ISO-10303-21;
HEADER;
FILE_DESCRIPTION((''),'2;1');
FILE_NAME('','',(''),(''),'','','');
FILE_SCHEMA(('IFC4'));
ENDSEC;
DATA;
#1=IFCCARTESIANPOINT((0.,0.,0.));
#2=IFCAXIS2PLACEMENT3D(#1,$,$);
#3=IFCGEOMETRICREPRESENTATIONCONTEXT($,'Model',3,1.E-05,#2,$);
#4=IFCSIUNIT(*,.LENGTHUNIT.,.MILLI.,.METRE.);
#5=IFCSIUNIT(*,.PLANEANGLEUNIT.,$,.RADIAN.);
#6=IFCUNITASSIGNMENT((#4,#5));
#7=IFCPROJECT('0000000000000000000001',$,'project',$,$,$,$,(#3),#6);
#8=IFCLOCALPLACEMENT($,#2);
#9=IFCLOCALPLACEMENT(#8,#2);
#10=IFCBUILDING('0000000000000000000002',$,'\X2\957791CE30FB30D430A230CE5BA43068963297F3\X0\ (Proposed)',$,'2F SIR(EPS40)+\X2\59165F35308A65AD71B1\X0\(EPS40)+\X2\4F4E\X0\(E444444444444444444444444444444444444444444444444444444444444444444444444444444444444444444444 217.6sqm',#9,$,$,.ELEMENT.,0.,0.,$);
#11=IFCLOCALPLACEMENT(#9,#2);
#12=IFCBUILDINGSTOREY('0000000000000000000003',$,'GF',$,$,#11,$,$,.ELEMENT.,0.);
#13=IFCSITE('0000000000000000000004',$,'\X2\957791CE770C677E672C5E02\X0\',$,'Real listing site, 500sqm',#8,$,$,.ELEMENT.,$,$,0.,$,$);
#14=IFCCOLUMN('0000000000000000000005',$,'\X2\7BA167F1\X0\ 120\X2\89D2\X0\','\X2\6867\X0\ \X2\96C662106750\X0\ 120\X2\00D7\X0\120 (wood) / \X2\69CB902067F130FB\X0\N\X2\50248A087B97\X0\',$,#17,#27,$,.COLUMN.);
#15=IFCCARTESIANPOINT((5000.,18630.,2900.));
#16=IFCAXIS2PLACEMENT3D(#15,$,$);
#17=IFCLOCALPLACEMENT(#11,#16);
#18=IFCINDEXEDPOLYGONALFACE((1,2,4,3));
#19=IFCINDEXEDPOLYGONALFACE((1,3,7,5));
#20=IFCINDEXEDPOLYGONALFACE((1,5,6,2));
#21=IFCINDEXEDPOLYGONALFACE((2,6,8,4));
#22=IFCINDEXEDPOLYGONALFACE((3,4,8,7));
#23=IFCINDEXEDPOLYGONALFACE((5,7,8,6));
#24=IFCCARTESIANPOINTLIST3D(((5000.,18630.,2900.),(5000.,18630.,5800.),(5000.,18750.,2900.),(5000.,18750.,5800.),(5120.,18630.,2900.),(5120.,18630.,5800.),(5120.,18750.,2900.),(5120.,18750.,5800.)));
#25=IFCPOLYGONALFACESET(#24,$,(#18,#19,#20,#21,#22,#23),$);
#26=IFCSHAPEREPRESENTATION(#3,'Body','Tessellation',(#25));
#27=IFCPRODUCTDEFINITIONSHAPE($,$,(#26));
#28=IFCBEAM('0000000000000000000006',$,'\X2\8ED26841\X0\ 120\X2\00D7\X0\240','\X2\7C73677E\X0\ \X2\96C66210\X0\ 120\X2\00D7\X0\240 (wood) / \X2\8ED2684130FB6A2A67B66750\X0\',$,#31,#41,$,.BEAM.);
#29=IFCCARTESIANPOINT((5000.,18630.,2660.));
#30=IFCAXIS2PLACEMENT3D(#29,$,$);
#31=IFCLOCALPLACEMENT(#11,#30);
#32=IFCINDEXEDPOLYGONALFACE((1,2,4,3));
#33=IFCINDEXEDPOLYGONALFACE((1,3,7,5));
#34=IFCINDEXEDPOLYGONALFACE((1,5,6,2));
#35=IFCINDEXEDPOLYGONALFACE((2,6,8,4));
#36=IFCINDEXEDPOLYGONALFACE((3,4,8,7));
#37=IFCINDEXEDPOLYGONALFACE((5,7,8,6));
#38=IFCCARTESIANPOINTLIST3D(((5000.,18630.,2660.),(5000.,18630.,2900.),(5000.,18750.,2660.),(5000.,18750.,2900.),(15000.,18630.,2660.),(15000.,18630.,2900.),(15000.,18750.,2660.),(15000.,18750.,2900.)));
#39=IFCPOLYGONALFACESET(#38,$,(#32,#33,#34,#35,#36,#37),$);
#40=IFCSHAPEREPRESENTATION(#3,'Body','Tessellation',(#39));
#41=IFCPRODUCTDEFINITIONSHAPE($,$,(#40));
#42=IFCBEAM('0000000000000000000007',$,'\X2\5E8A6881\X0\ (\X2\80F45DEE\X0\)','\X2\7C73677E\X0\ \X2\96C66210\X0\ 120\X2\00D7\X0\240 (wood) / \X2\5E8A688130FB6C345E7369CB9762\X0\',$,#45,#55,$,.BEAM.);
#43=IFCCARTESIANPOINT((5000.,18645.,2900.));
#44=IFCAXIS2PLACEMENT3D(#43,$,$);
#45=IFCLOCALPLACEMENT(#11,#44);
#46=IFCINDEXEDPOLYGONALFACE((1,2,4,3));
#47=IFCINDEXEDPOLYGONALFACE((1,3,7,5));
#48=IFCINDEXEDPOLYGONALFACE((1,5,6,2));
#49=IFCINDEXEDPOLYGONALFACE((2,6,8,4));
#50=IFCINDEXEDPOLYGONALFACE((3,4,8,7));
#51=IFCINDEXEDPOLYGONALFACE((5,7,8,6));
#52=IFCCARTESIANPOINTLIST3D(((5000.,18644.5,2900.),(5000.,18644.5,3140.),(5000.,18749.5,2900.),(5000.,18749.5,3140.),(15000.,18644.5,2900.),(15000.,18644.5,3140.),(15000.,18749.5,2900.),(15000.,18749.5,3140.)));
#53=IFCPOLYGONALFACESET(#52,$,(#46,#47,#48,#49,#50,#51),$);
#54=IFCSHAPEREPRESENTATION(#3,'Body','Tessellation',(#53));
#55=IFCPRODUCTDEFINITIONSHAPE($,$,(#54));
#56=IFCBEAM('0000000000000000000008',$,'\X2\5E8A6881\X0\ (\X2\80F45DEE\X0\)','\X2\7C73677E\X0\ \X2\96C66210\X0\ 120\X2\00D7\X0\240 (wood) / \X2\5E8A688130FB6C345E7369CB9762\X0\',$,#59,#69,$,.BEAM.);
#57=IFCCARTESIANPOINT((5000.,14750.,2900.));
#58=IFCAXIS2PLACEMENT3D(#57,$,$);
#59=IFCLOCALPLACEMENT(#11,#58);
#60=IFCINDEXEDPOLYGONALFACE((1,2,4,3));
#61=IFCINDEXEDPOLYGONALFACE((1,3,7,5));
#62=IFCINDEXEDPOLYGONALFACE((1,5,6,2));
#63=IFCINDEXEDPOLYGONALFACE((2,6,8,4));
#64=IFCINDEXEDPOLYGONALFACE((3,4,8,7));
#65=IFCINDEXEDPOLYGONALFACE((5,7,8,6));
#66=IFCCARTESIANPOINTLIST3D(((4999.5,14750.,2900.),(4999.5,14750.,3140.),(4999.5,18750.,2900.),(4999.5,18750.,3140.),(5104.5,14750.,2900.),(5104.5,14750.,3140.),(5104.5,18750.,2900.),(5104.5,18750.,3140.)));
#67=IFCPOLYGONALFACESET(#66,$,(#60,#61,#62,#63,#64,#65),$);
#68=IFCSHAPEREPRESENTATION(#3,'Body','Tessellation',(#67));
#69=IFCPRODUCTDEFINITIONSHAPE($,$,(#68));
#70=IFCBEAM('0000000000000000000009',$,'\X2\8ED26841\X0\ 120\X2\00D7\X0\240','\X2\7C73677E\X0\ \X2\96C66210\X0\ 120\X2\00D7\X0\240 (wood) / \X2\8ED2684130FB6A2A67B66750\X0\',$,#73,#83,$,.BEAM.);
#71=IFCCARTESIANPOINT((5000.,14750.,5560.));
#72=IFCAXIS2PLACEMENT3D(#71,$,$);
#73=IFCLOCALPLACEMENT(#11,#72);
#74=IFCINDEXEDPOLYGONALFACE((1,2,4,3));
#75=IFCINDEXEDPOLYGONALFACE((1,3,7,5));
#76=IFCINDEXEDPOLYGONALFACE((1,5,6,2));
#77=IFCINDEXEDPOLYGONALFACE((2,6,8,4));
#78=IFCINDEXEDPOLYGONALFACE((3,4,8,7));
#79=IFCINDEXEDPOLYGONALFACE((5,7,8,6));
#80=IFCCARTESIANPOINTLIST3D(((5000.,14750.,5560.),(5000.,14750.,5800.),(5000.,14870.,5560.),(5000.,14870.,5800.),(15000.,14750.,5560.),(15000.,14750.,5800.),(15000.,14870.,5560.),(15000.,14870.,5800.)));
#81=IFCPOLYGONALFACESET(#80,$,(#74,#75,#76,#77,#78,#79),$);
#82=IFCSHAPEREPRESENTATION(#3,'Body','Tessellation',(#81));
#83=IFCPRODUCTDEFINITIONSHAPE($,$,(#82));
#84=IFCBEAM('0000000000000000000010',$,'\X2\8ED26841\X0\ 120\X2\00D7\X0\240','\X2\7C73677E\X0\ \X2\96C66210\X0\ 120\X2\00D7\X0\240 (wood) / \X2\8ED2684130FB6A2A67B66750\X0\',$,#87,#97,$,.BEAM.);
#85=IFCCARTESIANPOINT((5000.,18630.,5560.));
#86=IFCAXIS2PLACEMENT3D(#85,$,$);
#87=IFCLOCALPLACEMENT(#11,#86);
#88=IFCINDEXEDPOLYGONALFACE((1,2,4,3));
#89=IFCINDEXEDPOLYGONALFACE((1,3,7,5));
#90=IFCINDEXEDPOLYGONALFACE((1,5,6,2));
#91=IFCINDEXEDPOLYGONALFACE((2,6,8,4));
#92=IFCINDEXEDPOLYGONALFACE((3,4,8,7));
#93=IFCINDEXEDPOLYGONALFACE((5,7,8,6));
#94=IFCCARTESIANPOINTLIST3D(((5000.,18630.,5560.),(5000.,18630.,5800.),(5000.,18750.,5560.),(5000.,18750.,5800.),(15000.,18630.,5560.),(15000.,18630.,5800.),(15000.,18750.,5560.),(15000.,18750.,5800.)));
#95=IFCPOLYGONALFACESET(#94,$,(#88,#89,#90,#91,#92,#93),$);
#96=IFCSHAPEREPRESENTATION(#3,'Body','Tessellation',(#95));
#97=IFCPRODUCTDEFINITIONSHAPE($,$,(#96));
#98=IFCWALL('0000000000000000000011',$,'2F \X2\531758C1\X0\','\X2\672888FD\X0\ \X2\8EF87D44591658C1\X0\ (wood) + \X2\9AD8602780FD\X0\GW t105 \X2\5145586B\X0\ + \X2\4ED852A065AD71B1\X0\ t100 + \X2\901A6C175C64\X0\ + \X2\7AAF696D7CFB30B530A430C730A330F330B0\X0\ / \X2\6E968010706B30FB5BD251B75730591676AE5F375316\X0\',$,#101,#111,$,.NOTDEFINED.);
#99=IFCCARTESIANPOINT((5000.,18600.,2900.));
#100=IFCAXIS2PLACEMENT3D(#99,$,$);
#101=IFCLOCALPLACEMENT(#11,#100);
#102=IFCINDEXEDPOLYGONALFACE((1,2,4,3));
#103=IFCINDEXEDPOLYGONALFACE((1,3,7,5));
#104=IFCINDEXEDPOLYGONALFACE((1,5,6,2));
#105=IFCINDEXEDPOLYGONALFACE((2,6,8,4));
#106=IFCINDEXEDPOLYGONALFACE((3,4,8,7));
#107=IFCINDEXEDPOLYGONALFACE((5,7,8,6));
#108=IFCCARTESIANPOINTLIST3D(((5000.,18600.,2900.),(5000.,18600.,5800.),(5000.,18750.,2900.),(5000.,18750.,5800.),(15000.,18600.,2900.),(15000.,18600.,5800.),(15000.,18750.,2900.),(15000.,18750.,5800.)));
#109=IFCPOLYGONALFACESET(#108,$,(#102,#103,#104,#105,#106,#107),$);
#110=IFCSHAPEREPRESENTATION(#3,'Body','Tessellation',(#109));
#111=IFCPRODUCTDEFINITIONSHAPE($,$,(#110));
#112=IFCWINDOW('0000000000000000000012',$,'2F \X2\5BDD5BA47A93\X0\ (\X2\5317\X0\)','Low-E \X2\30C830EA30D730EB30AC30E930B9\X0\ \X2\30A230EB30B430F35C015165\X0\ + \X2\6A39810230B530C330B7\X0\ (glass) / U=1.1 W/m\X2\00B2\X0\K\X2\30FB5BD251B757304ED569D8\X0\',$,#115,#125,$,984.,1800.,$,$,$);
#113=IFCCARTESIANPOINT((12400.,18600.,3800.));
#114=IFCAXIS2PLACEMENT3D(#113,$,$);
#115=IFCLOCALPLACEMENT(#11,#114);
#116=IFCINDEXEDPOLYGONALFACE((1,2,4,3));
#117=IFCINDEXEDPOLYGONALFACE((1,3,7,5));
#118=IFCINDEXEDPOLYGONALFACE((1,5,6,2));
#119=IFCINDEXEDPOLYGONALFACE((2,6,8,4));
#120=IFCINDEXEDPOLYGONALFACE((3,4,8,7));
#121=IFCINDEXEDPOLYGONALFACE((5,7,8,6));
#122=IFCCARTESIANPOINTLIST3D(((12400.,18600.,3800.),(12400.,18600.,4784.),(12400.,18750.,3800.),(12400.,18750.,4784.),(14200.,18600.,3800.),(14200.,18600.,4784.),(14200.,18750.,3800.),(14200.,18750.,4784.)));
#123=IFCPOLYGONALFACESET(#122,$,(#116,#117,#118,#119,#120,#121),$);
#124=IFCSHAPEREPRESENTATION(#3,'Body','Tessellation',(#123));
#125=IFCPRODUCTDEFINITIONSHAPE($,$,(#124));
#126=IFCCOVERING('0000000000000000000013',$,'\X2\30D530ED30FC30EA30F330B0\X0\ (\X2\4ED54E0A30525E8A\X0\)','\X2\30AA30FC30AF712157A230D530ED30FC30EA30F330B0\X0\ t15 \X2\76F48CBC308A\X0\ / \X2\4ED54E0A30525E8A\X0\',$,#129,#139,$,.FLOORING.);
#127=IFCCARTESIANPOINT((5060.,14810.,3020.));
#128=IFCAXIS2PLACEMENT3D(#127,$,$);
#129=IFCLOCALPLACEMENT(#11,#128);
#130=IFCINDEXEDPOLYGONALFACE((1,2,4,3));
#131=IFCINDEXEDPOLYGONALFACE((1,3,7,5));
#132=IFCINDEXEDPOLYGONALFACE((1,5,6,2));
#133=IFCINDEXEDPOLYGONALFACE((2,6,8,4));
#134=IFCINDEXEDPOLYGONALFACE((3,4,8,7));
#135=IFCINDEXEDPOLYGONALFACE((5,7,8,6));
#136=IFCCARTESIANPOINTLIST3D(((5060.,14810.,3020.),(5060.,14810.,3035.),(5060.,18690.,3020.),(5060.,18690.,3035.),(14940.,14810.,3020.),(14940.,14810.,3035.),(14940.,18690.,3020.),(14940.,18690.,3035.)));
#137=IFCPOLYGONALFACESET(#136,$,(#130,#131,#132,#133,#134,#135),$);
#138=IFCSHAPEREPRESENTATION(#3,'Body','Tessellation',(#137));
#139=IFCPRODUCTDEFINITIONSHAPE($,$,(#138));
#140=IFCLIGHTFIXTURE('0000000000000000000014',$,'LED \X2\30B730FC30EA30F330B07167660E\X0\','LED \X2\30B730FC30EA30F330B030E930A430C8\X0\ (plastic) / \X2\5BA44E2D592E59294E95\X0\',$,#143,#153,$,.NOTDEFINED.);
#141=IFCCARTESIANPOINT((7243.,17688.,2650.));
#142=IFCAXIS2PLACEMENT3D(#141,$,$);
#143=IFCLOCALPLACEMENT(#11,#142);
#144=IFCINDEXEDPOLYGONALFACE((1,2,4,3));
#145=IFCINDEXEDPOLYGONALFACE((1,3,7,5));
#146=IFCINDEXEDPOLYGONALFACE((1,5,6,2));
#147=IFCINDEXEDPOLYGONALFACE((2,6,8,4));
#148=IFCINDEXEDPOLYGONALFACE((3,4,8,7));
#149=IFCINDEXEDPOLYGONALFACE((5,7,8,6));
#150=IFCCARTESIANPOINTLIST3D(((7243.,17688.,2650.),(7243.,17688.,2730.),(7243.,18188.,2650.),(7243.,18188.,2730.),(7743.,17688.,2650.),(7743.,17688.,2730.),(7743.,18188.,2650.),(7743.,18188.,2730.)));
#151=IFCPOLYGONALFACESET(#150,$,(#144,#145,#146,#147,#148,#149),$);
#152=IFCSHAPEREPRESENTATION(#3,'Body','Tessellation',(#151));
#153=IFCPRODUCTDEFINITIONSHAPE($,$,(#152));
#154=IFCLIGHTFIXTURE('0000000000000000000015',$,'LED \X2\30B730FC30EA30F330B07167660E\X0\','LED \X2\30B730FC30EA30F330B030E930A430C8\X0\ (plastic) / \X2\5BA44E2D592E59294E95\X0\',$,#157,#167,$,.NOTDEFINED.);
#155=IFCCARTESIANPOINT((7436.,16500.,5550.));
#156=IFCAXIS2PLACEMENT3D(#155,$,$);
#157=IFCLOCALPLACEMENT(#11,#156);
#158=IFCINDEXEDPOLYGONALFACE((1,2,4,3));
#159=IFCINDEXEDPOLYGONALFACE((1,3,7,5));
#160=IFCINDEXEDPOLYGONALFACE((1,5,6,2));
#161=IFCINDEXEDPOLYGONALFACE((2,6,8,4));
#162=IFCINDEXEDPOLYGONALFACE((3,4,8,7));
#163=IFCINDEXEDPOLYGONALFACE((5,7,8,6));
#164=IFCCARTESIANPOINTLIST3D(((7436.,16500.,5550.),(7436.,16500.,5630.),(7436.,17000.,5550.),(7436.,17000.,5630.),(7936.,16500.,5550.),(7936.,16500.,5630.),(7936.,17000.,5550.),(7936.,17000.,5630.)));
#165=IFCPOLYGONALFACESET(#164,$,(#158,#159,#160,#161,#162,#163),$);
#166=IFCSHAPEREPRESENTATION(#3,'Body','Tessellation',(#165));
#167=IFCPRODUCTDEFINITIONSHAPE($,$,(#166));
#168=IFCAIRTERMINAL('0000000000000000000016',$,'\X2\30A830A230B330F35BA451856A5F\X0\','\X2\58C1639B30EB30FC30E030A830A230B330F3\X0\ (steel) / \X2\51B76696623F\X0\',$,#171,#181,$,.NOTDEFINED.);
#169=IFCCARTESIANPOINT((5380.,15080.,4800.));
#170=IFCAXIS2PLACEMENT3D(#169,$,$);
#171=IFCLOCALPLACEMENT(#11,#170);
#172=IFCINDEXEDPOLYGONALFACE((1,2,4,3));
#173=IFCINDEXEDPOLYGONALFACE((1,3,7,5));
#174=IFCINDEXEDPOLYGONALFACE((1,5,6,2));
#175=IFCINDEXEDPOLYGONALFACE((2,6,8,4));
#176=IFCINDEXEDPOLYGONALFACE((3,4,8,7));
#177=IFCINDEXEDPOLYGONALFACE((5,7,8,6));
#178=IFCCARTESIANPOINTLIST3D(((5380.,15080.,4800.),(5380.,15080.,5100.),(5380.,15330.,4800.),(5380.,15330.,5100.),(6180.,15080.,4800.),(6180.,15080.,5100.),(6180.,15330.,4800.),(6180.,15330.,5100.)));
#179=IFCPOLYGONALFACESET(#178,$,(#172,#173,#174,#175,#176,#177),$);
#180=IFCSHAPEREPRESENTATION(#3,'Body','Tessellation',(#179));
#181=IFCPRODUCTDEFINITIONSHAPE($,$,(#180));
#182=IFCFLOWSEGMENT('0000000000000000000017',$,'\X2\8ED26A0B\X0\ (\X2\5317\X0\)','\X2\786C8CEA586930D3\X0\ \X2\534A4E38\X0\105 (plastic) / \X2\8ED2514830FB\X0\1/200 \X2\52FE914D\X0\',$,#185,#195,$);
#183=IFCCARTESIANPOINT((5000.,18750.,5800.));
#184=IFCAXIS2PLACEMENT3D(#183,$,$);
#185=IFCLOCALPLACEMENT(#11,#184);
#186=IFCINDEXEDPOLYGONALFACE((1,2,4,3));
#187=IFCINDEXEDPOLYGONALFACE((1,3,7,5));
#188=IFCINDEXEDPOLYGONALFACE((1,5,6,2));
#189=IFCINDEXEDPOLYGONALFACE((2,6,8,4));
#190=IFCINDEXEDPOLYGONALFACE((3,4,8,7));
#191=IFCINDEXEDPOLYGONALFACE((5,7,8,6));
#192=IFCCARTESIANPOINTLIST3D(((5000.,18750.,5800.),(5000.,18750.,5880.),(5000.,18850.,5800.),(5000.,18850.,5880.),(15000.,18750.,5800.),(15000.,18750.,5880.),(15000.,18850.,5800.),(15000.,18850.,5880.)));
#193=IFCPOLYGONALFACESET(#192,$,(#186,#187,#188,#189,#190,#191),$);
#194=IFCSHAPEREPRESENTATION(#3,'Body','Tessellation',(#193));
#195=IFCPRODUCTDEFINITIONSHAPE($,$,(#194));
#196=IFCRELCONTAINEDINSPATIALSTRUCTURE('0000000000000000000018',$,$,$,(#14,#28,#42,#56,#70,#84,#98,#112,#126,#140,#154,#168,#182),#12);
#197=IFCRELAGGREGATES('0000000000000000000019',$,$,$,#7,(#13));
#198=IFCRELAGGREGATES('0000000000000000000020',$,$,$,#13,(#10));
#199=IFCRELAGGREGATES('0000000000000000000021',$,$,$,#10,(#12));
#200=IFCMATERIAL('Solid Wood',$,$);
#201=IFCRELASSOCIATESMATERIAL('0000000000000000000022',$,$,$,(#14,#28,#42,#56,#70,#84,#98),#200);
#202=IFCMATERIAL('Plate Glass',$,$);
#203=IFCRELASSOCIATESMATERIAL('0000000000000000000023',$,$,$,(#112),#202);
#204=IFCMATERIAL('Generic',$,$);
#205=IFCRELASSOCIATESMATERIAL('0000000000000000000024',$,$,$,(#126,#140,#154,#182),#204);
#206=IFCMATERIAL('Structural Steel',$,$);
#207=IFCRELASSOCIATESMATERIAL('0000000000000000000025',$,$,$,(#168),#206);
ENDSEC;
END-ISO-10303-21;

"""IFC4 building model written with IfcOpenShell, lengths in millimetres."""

from ifc_helpers import new_model, si_unit, frame, frame_2d, origin, place, context, project, spatial, rectangle, extrude, material, element, fill, save


model = new_model("IFC4")

# Units and contexts
model_context = context("Model", 3, precision=1e-05, world=origin())
ifc_project = project(units=[si_unit("LENGTHUNIT", "METRE", prefix="MILLI"), si_unit("PLANEANGLEUNIT", "RADIAN")], contexts=[model_context])

# Site, building, storey
site_placement = place(None, origin())
site = spatial("IfcSite", under=ifc_project, at=site_placement, Name="長野県松本市", ObjectType="Real listing site, 500sqm", CompositionType="ELEMENT", RefElevation=0.0)
building_placement = place(site_placement, origin())
building = spatial("IfcBuilding", under=site, at=building_placement, Name="長野・ピアノ室と防音 (Proposed)", ObjectType="2F SIR(EPS40)+外張り断熱(EPS40)+低(E444444444444444444444444444444444444444444444444444444444444444444444444444444444444444444444 217.6sqm", CompositionType="ELEMENT", ElevationOfRefHeight=0.0, ElevationOfTerrain=0.0)
storey_placement = place(building_placement, origin())
storey = spatial("IfcBuildingStorey", under=building, at=storey_placement, Name="GF", CompositionType="ELEMENT", Elevation=0.0)

# Column
ifc_material_1 = material(Name="Solid Wood")
column_1_placement = place(storey_placement, frame((5000.0, 18630.0, 2900.0)))
element("IfcColumn", 1, at=column_1_placement, inside=storey, material=ifc_material_1, Name="管柱 120角", Description="桧 集成材 120×120 (wood) / 構造柱・N値計算", PredefinedType="COLUMN", context=model_context, shape_type="SweptSolid", body=[
    extrude(rectangle(XDim=120.0, YDim=120.0, at=frame_2d((60.0, 60.0))), frame((5000.0, 18630.0, 2900.0)), (0.0, 0.0, 1.0), 2900.0),
])

# Beams
beam_1_placement = place(storey_placement, frame((5000.0, 18630.0, 2660.0)))
element("IfcBeam", 2, at=beam_1_placement, inside=storey, material=ifc_material_1, Name="軒桁 120×240", Description="米松 集成 120×240 (wood) / 軒桁・横架材", PredefinedType="BEAM", context=model_context, shape_type="SweptSolid", body=[
    extrude(rectangle(XDim=10000.0, YDim=120.0, at=frame_2d((5000.0, 60.0))), frame((5000.0, 18630.0, 2660.0)), (0.0, 0.0, 1.0), 240.0),
])
beam_2_placement = place(storey_placement, frame((5000.0, 18645.0, 2900.0)))
element("IfcBeam", 3, at=beam_2_placement, inside=storey, material=ifc_material_1, Name="床梁 (胴差)", Description="米松 集成 120×240 (wood) / 床梁・水平構面", PredefinedType="BEAM", context=model_context, shape_type="SweptSolid", body=[
    extrude(rectangle(XDim=10000.0, YDim=105.0, at=frame_2d((5000.0, 52.0))), frame((5000.0, 18645.0, 2900.0)), (0.0, 0.0, 1.0), 240.0),
])
beam_3_placement = place(storey_placement, frame((5000.0, 14750.0, 2900.0)))
element("IfcBeam", 4, at=beam_3_placement, inside=storey, material=ifc_material_1, Name="床梁 (胴差)", Description="米松 集成 120×240 (wood) / 床梁・水平構面", PredefinedType="BEAM", context=model_context, shape_type="SweptSolid", body=[
    extrude(rectangle(XDim=105.0, YDim=4000.0, at=frame_2d((52.0, 2000.0))), frame((5000.0, 14750.0, 2900.0)), (0.0, 0.0, 1.0), 240.0),
])
beam_4_placement = place(storey_placement, frame((5000.0, 14750.0, 5560.0)))
element("IfcBeam", 5, at=beam_4_placement, inside=storey, material=ifc_material_1, Name="軒桁 120×240", Description="米松 集成 120×240 (wood) / 軒桁・横架材", PredefinedType="BEAM", context=model_context, shape_type="SweptSolid", body=[
    extrude(rectangle(XDim=10000.0, YDim=120.0, at=frame_2d((5000.0, 60.0))), frame((5000.0, 14750.0, 5560.0)), (0.0, 0.0, 1.0), 240.0),
])
beam_5_placement = place(storey_placement, frame((5000.0, 18630.0, 5560.0)))
element("IfcBeam", 6, at=beam_5_placement, inside=storey, material=ifc_material_1, Name="軒桁 120×240", Description="米松 集成 120×240 (wood) / 軒桁・横架材", PredefinedType="BEAM", context=model_context, shape_type="SweptSolid", body=[
    extrude(rectangle(XDim=10000.0, YDim=120.0, at=frame_2d((5000.0, 60.0))), frame((5000.0, 18630.0, 5560.0)), (0.0, 0.0, 1.0), 240.0),
])

# Wall, opening, window
wall_placement = place(storey_placement, frame((5000.0, 18600.0, 2900.0)))
wall = element("IfcWall", 7, at=wall_placement, inside=storey, material=ifc_material_1, Name="2F 北壁", Description="木製 軸組外壁 (wood) + 高性能GW t105 充填 + 付加断熱 t100 + 通気層 + 窯業系サイディング / 準耐火・寒冷地外皮強化", PredefinedType="NOTDEFINED", context=model_context, shape_type="SweptSolid", body=[
    extrude(rectangle(XDim=10000.0, YDim=150.0, at=frame_2d((5000.0, 75.0))), frame((5000.0, 18600.0, 2900.0)), (0.0, 0.0, 1.0), 2900.0),
])
opening_placement = place(storey_placement, frame((12400.0, 18600.0, 3800.0)))
opening = element("IfcOpeningElement", 8, at=opening_placement, cuts=wall, PredefinedType="NOTDEFINED", context=model_context, shape_type="SweptSolid", body=[
    extrude(rectangle(XDim=1800.0, YDim=150.0, at=frame_2d((900.0, 75.0))), frame((12400.0, 18600.0, 3800.0)), (0.0, 0.0, 1.0), 984.0),
])
ifc_material_2 = material(Name="Plate Glass")
window_placement = place(storey_placement, frame((12400.0, 18600.0, 3800.0)))
window = element("IfcWindow", 9, at=window_placement, inside=storey, material=ifc_material_2, Name="2F 寝室窓 (北)", Description="Low-E トリプルガラス アルゴン封入 + 樹脂サッシ (glass) / U=1.1 W/m²K・寒冷地仕様", OverallHeight=984.0, OverallWidth=1800.0, context=model_context, shape_type="SweptSolid", body=[
    extrude(rectangle(XDim=1800.0, YDim=150.0, at=frame_2d((900.0, 75.0))), frame((12400.0, 18600.0, 3800.0)), (0.0, 0.0, 1.0), 984.0),
])
fill(opening, window)

# Covering
ifc_material_3 = material(Name="Generic")
covering_placement = place(storey_placement, frame((5060.0, 14810.0, 3020.0)))
element("IfcCovering", 10, at=covering_placement, inside=storey, material=ifc_material_3, Name="フローリング (仕上げ床)", Description="オーク無垢フローリング t15 直貼り / 仕上げ床", PredefinedType="FLOORING", context=model_context, shape_type="SweptSolid", body=[
    extrude(rectangle(XDim=9880.0, YDim=3880.0, at=frame_2d((4940.0, 1940.0))), frame((5060.0, 14810.0, 3020.0)), (0.0, 0.0, 1.0), 15.0),
])

# Light fixtures
light_fixture_1_placement = place(storey_placement, frame((7243.0, 17688.0, 2650.0)))
element("IfcLightFixture", 11, at=light_fixture_1_placement, inside=storey, material=ifc_material_3, Name="LED シーリング照明", Description="LED シーリングライト (plastic) / 室中央天井", PredefinedType="NOTDEFINED", context=model_context, shape_type="SweptSolid", body=[
    extrude(rectangle(XDim=500.0, YDim=500.0, at=frame_2d((250.0, 250.0))), frame((7243.0, 17688.0, 2650.0)), (0.0, 0.0, 1.0), 80.0),
])
light_fixture_2_placement = place(storey_placement, frame((7436.0, 16500.0, 5550.0)))
element("IfcLightFixture", 12, at=light_fixture_2_placement, inside=storey, material=ifc_material_3, Name="LED シーリング照明", Description="LED シーリングライト (plastic) / 室中央天井", PredefinedType="NOTDEFINED", context=model_context, shape_type="SweptSolid", body=[
    extrude(rectangle(XDim=500.0, YDim=500.0, at=frame_2d((250.0, 250.0))), frame((7436.0, 16500.0, 5550.0)), (0.0, 0.0, 1.0), 80.0),
])

# Air terminal
ifc_material_4 = material(Name="Structural Steel")
air_terminal_placement = place(storey_placement, frame((5380.0, 15080.0, 4800.0)))
element("IfcAirTerminal", 13, at=air_terminal_placement, inside=storey, material=ifc_material_4, Name="エアコン室内機", Description="壁掛ルームエアコン (steel) / 冷暖房", PredefinedType="NOTDEFINED", context=model_context, shape_type="SweptSolid", body=[
    extrude(rectangle(XDim=800.0, YDim=250.0, at=frame_2d((400.0, 125.0))), frame((5380.0, 15080.0, 4800.0)), (0.0, 0.0, 1.0), 300.0),
])

# Flow segment
flow_segment_placement = place(storey_placement, frame((5000.0, 18750.0, 5800.0)))
element("IfcFlowSegment", 14, at=flow_segment_placement, inside=storey, material=ifc_material_3, Name="軒樋 (北)", Description="硬質塩ビ 半丸105 (plastic) / 軒先・1/200 勾配", context=model_context, shape_type="SweptSolid", body=[
    extrude(rectangle(XDim=10000.0, YDim=100.0, at=frame_2d((5000.0, 50.0))), frame((5000.0, 18750.0, 5800.0)), (0.0, 0.0, 1.0), 80.0),
])

save(model, "model.ifc")
